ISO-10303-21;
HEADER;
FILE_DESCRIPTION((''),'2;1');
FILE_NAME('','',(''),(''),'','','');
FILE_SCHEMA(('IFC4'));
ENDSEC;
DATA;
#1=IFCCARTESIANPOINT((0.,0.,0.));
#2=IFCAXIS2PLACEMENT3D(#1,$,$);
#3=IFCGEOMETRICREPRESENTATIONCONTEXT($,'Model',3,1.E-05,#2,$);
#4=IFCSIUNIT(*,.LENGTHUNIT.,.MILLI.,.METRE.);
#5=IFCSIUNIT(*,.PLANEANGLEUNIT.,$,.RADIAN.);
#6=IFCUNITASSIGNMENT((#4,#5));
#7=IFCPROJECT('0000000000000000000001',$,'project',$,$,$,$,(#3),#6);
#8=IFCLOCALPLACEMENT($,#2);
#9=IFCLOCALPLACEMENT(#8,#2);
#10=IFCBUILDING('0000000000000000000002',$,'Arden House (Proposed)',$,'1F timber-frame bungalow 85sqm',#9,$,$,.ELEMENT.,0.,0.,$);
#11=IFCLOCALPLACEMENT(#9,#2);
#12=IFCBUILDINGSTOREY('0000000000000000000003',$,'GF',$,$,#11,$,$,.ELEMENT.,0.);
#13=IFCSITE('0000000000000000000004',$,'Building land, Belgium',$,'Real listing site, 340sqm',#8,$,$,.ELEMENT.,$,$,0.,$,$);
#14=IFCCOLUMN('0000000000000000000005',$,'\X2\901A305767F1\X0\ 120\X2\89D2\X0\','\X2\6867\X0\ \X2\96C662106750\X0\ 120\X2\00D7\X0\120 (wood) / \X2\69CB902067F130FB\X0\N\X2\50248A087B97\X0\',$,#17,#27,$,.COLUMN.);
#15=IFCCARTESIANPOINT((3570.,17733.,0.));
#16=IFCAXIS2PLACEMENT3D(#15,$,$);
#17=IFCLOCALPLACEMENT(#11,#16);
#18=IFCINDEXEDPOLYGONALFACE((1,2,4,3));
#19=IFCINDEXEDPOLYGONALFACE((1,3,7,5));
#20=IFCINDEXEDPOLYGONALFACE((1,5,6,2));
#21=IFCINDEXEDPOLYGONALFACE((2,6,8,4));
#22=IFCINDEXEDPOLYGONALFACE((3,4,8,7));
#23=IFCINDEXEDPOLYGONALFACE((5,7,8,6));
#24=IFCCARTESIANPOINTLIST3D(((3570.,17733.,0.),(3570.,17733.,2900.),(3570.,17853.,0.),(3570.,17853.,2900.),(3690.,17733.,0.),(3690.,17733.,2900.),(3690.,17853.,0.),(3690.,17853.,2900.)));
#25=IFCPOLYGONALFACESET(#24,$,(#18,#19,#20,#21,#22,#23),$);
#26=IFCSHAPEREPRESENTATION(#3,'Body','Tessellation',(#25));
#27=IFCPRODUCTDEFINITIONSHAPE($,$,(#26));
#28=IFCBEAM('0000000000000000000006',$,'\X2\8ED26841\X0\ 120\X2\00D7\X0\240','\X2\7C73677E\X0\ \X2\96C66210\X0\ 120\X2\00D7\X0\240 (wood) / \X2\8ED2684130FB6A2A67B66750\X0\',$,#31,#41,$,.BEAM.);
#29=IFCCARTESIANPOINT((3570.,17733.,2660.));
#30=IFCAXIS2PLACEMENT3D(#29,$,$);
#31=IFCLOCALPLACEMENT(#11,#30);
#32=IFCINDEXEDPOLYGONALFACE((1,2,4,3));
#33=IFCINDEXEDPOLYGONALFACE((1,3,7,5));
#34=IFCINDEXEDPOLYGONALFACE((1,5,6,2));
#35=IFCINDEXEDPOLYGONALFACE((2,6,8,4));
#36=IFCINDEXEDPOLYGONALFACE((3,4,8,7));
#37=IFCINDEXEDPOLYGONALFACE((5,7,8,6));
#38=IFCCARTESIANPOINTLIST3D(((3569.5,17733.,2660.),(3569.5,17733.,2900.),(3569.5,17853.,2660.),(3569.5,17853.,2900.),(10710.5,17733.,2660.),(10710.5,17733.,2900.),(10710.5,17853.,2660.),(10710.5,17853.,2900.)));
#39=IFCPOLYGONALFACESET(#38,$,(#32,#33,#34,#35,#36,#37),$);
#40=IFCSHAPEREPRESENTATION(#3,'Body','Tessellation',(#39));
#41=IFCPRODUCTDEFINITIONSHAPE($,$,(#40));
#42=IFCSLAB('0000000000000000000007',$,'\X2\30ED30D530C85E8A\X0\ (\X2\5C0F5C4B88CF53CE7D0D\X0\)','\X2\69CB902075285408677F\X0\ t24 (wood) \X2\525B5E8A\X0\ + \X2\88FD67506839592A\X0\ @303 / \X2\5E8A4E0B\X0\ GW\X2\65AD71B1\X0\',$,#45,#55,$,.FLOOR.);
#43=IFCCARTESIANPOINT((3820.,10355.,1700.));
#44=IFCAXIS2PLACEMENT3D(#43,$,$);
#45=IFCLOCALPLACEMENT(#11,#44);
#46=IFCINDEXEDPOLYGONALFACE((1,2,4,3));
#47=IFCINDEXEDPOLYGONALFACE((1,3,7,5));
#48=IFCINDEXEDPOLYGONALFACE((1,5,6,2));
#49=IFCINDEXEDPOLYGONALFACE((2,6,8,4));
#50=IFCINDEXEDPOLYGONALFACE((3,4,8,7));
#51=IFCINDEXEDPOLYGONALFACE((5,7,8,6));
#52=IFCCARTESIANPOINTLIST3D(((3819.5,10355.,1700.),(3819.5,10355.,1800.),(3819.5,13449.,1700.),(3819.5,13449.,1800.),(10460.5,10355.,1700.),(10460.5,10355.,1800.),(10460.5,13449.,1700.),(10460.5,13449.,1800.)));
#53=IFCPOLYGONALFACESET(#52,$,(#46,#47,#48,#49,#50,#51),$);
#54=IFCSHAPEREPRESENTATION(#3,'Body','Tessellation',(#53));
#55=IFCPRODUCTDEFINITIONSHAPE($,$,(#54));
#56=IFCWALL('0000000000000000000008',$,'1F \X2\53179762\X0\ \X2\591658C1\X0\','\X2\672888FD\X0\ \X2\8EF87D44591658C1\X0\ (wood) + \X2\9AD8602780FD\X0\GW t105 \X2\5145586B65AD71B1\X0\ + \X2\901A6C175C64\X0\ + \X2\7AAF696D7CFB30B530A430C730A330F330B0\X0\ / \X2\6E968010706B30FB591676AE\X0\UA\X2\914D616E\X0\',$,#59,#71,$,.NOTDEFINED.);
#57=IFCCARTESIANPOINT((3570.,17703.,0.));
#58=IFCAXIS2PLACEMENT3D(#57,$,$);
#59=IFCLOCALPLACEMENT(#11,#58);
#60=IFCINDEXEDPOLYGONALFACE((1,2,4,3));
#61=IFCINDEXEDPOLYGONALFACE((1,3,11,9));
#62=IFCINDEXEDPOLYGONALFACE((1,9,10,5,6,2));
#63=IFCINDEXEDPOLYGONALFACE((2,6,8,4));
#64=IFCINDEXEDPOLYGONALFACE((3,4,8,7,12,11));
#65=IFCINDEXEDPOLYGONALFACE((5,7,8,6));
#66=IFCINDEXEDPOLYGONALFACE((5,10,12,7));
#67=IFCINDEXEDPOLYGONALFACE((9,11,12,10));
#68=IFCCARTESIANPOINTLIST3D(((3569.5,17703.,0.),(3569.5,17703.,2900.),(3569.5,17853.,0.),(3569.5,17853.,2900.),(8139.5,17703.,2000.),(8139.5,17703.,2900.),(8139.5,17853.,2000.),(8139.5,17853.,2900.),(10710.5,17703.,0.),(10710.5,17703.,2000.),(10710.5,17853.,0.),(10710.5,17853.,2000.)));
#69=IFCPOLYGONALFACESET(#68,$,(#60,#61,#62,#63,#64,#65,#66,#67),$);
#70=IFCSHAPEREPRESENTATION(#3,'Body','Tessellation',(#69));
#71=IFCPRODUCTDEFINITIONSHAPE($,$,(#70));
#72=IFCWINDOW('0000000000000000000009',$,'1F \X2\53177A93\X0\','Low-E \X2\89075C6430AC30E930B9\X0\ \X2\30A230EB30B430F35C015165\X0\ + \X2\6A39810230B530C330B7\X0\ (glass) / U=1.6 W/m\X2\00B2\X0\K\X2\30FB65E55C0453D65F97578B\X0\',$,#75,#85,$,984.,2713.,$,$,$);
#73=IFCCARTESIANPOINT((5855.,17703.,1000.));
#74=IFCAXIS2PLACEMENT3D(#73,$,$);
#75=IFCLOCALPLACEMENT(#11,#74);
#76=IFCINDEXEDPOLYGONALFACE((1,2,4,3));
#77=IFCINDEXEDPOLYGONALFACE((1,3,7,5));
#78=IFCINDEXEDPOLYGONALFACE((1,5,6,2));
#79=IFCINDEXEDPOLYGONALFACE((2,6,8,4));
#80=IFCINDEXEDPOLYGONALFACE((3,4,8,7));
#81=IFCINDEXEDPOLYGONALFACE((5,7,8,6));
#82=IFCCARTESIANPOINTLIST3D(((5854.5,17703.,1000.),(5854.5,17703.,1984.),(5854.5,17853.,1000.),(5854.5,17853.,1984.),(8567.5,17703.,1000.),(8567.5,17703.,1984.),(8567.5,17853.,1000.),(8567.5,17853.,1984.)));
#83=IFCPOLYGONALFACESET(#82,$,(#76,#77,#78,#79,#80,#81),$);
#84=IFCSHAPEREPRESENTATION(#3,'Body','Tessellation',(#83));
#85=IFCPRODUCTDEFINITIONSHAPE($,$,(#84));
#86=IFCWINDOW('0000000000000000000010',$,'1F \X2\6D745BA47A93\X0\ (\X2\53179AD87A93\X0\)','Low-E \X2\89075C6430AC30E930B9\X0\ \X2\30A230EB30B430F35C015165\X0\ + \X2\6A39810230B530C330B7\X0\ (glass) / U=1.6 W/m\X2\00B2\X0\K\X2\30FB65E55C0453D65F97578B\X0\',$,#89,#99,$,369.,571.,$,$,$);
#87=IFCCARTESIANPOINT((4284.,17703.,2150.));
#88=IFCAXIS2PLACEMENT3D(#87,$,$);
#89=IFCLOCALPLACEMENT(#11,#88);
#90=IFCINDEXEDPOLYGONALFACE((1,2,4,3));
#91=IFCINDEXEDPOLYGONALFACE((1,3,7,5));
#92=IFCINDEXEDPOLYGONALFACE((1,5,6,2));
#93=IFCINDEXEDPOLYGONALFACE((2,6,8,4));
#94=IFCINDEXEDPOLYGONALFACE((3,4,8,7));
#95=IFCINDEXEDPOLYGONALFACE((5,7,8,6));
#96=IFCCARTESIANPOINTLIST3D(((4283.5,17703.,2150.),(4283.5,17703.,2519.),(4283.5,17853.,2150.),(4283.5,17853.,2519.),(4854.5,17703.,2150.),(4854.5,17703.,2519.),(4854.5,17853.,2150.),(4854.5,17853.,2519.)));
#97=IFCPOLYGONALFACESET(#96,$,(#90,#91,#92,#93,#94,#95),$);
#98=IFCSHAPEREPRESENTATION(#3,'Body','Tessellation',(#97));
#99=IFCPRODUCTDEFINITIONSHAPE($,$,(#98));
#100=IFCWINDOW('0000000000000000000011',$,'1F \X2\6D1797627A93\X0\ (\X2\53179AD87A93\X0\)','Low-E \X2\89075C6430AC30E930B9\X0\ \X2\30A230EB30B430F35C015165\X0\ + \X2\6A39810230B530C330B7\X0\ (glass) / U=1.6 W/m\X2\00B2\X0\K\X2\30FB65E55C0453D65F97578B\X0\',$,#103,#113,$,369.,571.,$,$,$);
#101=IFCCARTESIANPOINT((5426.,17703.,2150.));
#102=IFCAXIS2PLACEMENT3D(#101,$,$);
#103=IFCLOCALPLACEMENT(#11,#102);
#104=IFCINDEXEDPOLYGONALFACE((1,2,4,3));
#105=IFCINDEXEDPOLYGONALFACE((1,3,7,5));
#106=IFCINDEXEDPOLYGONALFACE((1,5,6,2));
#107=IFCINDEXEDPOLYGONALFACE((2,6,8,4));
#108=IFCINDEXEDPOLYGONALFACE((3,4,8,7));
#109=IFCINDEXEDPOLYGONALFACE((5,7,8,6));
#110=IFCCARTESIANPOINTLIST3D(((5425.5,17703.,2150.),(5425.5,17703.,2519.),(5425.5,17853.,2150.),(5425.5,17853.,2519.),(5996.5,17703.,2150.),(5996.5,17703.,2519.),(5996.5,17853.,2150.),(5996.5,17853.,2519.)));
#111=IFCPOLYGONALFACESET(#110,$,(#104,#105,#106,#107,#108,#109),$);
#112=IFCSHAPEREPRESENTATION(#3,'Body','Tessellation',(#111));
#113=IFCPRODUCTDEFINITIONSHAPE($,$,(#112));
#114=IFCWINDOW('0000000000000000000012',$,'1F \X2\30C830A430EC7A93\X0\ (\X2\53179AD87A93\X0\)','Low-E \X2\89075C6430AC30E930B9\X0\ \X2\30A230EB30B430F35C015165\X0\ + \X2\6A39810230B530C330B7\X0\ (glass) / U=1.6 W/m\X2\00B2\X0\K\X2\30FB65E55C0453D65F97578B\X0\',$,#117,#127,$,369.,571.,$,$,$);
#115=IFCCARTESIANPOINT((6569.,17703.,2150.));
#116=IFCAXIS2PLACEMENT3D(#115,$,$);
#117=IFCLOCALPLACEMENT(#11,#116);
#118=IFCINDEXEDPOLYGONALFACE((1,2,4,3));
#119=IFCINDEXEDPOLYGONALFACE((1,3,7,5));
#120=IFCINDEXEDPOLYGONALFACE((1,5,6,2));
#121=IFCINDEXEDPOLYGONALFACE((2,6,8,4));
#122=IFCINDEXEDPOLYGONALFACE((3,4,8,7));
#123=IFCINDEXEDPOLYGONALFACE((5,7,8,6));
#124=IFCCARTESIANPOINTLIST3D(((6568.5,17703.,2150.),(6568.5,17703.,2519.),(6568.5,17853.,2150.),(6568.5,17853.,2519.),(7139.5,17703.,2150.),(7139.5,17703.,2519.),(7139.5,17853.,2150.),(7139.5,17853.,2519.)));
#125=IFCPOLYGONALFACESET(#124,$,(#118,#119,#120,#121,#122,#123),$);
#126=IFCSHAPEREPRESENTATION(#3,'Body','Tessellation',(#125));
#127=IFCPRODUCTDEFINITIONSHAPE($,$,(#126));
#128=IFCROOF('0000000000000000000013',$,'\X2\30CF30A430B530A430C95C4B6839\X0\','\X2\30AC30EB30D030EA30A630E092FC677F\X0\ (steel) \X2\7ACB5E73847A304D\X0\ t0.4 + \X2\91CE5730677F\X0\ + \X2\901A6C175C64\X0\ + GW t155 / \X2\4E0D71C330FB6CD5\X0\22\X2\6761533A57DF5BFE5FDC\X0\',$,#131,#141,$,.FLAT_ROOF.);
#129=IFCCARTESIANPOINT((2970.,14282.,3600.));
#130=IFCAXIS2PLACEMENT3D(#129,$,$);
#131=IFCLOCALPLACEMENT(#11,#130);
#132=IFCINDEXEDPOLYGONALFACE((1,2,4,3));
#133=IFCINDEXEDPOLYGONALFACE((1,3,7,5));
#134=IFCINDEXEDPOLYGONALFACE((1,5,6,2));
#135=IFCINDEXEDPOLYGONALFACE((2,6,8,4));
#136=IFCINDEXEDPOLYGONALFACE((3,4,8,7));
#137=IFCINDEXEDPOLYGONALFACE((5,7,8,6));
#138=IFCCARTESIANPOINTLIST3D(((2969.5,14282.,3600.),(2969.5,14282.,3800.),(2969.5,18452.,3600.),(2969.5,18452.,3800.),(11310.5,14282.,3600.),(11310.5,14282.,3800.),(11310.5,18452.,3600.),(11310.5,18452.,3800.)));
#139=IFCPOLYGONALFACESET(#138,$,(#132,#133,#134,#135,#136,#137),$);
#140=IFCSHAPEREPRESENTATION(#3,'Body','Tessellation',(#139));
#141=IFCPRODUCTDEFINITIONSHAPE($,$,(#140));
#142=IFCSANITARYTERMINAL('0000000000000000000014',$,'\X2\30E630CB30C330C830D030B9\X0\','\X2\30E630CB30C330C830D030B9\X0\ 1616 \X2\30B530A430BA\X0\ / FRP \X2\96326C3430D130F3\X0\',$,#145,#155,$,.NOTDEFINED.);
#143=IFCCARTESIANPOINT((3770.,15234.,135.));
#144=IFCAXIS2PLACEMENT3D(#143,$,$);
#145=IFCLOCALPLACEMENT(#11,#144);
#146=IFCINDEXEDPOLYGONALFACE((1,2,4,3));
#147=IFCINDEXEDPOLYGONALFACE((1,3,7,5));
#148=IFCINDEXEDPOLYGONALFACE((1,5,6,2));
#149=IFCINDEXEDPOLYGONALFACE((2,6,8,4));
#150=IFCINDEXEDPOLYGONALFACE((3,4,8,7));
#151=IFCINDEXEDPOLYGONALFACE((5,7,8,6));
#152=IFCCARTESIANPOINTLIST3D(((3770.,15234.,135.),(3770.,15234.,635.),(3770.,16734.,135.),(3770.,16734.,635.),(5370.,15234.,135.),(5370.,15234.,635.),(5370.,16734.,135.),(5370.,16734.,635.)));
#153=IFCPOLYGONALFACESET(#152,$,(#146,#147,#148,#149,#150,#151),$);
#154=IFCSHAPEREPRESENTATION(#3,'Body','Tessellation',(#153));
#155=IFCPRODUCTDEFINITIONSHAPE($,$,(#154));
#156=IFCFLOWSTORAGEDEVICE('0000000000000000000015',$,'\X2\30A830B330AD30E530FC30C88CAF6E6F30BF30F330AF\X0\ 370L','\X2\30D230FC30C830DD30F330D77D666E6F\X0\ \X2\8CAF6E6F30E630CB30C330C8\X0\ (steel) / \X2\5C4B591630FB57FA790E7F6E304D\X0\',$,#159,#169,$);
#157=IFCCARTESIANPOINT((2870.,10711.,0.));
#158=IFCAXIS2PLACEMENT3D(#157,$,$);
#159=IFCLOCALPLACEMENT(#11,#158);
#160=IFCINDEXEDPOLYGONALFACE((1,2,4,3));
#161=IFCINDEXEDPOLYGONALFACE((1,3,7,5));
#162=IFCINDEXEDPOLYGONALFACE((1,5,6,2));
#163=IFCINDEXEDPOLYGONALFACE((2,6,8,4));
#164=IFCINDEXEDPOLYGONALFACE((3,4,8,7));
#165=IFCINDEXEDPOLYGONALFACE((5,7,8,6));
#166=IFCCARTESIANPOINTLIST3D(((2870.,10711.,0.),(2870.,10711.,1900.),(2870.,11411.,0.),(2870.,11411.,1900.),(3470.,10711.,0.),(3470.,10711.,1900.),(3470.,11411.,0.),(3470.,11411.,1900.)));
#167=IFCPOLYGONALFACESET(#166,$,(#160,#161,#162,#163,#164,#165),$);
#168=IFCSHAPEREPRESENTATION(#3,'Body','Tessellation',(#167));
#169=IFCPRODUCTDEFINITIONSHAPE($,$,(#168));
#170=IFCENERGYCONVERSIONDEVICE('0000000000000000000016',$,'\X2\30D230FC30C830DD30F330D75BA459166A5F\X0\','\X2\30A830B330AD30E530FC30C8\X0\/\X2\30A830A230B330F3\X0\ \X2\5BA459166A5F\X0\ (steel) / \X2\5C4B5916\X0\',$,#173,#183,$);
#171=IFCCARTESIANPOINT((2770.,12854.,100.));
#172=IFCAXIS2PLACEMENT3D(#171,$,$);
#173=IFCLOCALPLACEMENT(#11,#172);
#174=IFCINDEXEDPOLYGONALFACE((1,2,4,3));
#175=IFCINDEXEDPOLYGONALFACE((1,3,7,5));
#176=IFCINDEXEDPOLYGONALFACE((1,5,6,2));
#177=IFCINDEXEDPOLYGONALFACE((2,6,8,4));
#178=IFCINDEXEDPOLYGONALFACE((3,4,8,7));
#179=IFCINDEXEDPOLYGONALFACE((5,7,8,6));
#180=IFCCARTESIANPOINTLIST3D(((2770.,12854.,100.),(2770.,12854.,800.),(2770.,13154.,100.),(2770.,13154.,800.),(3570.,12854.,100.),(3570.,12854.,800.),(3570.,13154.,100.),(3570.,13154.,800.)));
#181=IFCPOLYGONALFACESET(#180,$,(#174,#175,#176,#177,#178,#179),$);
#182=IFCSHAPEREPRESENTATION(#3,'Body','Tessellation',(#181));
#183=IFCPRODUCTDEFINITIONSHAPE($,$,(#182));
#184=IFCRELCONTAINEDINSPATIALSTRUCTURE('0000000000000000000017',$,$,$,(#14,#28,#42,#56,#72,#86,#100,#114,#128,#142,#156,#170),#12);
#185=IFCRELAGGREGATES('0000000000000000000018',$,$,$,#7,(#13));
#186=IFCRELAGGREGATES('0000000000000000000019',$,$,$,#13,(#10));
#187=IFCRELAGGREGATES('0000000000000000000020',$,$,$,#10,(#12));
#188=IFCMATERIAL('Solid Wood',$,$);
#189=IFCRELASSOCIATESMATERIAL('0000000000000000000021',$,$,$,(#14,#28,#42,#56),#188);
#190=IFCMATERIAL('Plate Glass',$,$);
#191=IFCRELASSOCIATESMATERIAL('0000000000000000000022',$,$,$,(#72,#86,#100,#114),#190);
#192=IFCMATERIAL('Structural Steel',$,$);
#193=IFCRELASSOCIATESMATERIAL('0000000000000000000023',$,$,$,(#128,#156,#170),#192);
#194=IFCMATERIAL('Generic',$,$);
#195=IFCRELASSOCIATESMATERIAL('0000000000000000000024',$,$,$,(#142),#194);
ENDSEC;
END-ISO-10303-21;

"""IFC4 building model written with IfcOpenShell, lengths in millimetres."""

from ifc_helpers import new_model, si_unit, frame, frame_2d, origin, place, context, project, spatial, rectangle, extrude, material, element, fill, save


model = new_model("IFC4")

# Units and contexts
model_context = context("Model", 3, precision=1e-05, world=origin())
ifc_project = project(units=[si_unit("LENGTHUNIT", "METRE", prefix="MILLI"), si_unit("PLANEANGLEUNIT", "RADIAN")], contexts=[model_context])

# Site, building, storey
site_placement = place(None, origin())
site = spatial("IfcSite", under=ifc_project, at=site_placement, Name="Building land, Belgium", ObjectType="Real listing site, 340sqm", CompositionType="ELEMENT", RefElevation=0.0)
building_placement = place(site_placement, origin())
building = spatial("IfcBuilding", under=site, at=building_placement, Name="Arden House (Proposed)", ObjectType="1F timber-frame bungalow 85sqm", CompositionType="ELEMENT", ElevationOfRefHeight=0.0, ElevationOfTerrain=0.0)
storey_placement = place(building_placement, origin())
storey = spatial("IfcBuildingStorey", under=building, at=storey_placement, Name="GF", CompositionType="ELEMENT", Elevation=0.0)

# Column
ifc_material_1 = material(Name="Solid Wood")
column_1_placement = place(storey_placement, frame((3570.0, 17733.0, 0.0)))
element("IfcColumn", 1, at=column_1_placement, inside=storey, material=ifc_material_1, Name="通し柱 120角", Description="桧 集成材 120×120 (wood) / 構造柱・N値計算", PredefinedType="COLUMN", context=model_context, shape_type="SweptSolid", body=[
    extrude(rectangle(XDim=120.0, YDim=120.0, at=frame_2d((60.0, 60.0))), frame((3570.0, 17733.0, 0.0)), (0.0, 0.0, 1.0), 2900.0),
])

# Beam
beam_1_placement = place(storey_placement, frame((3570.0, 17733.0, 2660.0)))
element("IfcBeam", 2, at=beam_1_placement, inside=storey, material=ifc_material_1, Name="軒桁 120×240", Description="米松 集成 120×240 (wood) / 軒桁・横架材", PredefinedType="BEAM", context=model_context, shape_type="SweptSolid", body=[
    extrude(rectangle(XDim=7141.0, YDim=120.0, at=frame_2d((3570.0, 60.0))), frame((3570.0, 17733.0, 2660.0)), (0.0, 0.0, 1.0), 240.0),
])

# Slab
slab_placement = place(storey_placement, frame((3820.0, 10355.0, 1700.0)))
element("IfcSlab", 3, at=slab_placement, inside=storey, material=ifc_material_1, Name="ロフト床 (小屋裏収納)", Description="構造用合板 t24 (wood) 剛床 + 製材根太 @303 / 床下 GW断熱", PredefinedType="FLOOR", context=model_context, shape_type="SweptSolid", body=[
    extrude(rectangle(XDim=6641.0, YDim=3094.0, at=frame_2d((3320.0, 1547.0))), frame((3820.0, 10355.0, 1700.0)), (0.0, 0.0, 1.0), 100.0),
])

# Wall, openings, windows
wall_1_placement = place(storey_placement, frame((3570.0, 17703.0, 0.0)))
wall_1 = element("IfcWall", 4, at=wall_1_placement, inside=storey, material=ifc_material_1, Name="1F 北面 外壁", Description="木製 軸組外壁 (wood) + 高性能GW t105 充填断熱 + 通気層 + 窯業系サイディング / 準耐火・外皮UA配慮", PredefinedType="NOTDEFINED", context=model_context, shape_type="SweptSolid", body=[
    extrude(rectangle(XDim=7141.0, YDim=150.0, at=frame_2d((3570.0, 75.0))), frame((3570.0, 17703.0, 0.0)), (0.0, 0.0, 1.0), 2900.0),
])
opening_1_placement = place(storey_placement, frame((5855.0, 17703.0, 1000.0)))
opening_1 = element("IfcOpeningElement", 5, at=opening_1_placement, cuts=wall_1, PredefinedType="NOTDEFINED", context=model_context, shape_type="SweptSolid", body=[
    extrude(rectangle(XDim=2713.0, YDim=150.0, at=frame_2d((1356.0, 75.0))), frame((5855.0, 17703.0, 1000.0)), (0.0, 0.0, 1.0), 984.0),
])
opening_2_placement = place(storey_placement, frame((4284.0, 17703.0, 2150.0)))
opening_2 = element("IfcOpeningElement", 6, at=opening_2_placement, cuts=wall_1, PredefinedType="NOTDEFINED", context=model_context, shape_type="SweptSolid", body=[
    extrude(rectangle(XDim=571.0, YDim=150.0, at=frame_2d((285.0, 75.0))), frame((4284.0, 17703.0, 2150.0)), (0.0, 0.0, 1.0), 369.0),
])
opening_3_placement = place(storey_placement, frame((5426.0, 17703.0, 2150.0)))
opening_3 = element("IfcOpeningElement", 7, at=opening_3_placement, cuts=wall_1, PredefinedType="NOTDEFINED", context=model_context, shape_type="SweptSolid", body=[
    extrude(rectangle(XDim=571.0, YDim=150.0, at=frame_2d((285.0, 75.0))), frame((5426.0, 17703.0, 2150.0)), (0.0, 0.0, 1.0), 369.0),
])
opening_4_placement = place(storey_placement, frame((6569.0, 17703.0, 2150.0)))
opening_4 = element("IfcOpeningElement", 8, at=opening_4_placement, cuts=wall_1, PredefinedType="NOTDEFINED", context=model_context, shape_type="SweptSolid", body=[
    extrude(rectangle(XDim=571.0, YDim=150.0, at=frame_2d((285.0, 75.0))), frame((6569.0, 17703.0, 2150.0)), (0.0, 0.0, 1.0), 369.0),
])
ifc_material_2 = material(Name="Plate Glass")
window_1_placement = place(storey_placement, frame((5855.0, 17703.0, 1000.0)))
window_1 = element("IfcWindow", 9, at=window_1_placement, inside=storey, material=ifc_material_2, Name="1F 北窓", Description="Low-E 複層ガラス アルゴン封入 + 樹脂サッシ (glass) / U=1.6 W/m²K・日射取得型", OverallHeight=984.0, OverallWidth=2713.0, context=model_context, shape_type="SweptSolid", body=[
    extrude(rectangle(XDim=2713.0, YDim=150.0, at=frame_2d((1356.0, 75.0))), frame((5855.0, 17703.0, 1000.0)), (0.0, 0.0, 1.0), 984.0),
])
fill(opening_1, window_1)
window_2_placement = place(storey_placement, frame((4284.0, 17703.0, 2150.0)))
window_2 = element("IfcWindow", 10, at=window_2_placement, inside=storey, material=ifc_material_2, Name="1F 浴室窓 (北高窓)", Description="Low-E 複層ガラス アルゴン封入 + 樹脂サッシ (glass) / U=1.6 W/m²K・日射取得型", OverallHeight=369.0, OverallWidth=571.0, context=model_context, shape_type="SweptSolid", body=[
    extrude(rectangle(XDim=571.0, YDim=150.0, at=frame_2d((285.0, 75.0))), frame((4284.0, 17703.0, 2150.0)), (0.0, 0.0, 1.0), 369.0),
])
fill(opening_2, window_2)
window_3_placement = place(storey_placement, frame((5426.0, 17703.0, 2150.0)))
window_3 = element("IfcWindow", 11, at=window_3_placement, inside=storey, material=ifc_material_2, Name="1F 洗面窓 (北高窓)", Description="Low-E 複層ガラス アルゴン封入 + 樹脂サッシ (glass) / U=1.6 W/m²K・日射取得型", OverallHeight=369.0, OverallWidth=571.0, context=model_context, shape_type="SweptSolid", body=[
    extrude(rectangle(XDim=571.0, YDim=150.0, at=frame_2d((285.0, 75.0))), frame((5426.0, 17703.0, 2150.0)), (0.0, 0.0, 1.0), 369.0),
])
fill(opening_3, window_3)
window_4_placement = place(storey_placement, frame((6569.0, 17703.0, 2150.0)))
window_4 = element("IfcWindow", 12, at=window_4_placement, inside=storey, material=ifc_material_2, Name="1F トイレ窓 (北高窓)", Description="Low-E 複層ガラス アルゴン封入 + 樹脂サッシ (glass) / U=1.6 W/m²K・日射取得型", OverallHeight=369.0, OverallWidth=571.0, context=model_context, shape_type="SweptSolid", body=[
    extrude(rectangle(XDim=571.0, YDim=150.0, at=frame_2d((285.0, 75.0))), frame((6569.0, 17703.0, 2150.0)), (0.0, 0.0, 1.0), 369.0),
])
fill(opening_4, window_4)

# Roof
ifc_material_3 = material(Name="Structural Steel")
roof_placement = place(storey_placement, frame((2970.0, 14282.0, 3600.0)))
element("IfcRoof", 13, at=roof_placement, inside=storey, material=ifc_material_3, Name="ハイサイド屋根", Description="ガルバリウム鋼板 (steel) 立平葺き t0.4 + 野地板 + 通気層 + GW t155 / 不燃・法22条区域対応", PredefinedType="FLAT_ROOF", context=model_context, shape_type="SweptSolid", body=[
    extrude(rectangle(XDim=8341.0, YDim=4170.0, at=frame_2d((4170.0, 2085.0))), frame((2970.0, 14282.0, 3600.0)), (0.0, 0.0, 1.0), 200.0),
])

# Sanitary terminal
ifc_material_4 = material(Name="Generic")
sanitary_terminal_placement = place(storey_placement, frame((3770.0, 15234.0, 135.0)))
element("IfcSanitaryTerminal", 14, at=sanitary_terminal_placement, inside=storey, material=ifc_material_4, Name="ユニットバス", Description="ユニットバス 1616 サイズ / FRP 防水パン", PredefinedType="NOTDEFINED", context=model_context, shape_type="SweptSolid", body=[
    extrude(rectangle(XDim=1600.0, YDim=1500.0, at=frame_2d((800.0, 750.0))), frame((3770.0, 15234.0, 135.0)), (0.0, 0.0, 1.0), 500.0),
])

# Flow storage device
flow_storage_device_placement = place(storey_placement, frame((2870.0, 10711.0, 0.0)))
element("IfcFlowStorageDevice", 15, at=flow_storage_device_placement, inside=storey, material=ifc_material_3, Name="エコキュート貯湯タンク 370L", Description="ヒートポンプ給湯 貯湯ユニット (steel) / 屋外・基礎置き", context=model_context, shape_type="SweptSolid", body=[
    extrude(rectangle(XDim=600.0, YDim=700.0, at=frame_2d((300.0, 350.0))), frame((2870.0, 10711.0, 0.0)), (0.0, 0.0, 1.0), 1900.0),
])

# Energy conversion device
energy_conversion_device_placement = place(storey_placement, frame((2770.0, 12854.0, 100.0)))
element("IfcEnergyConversionDevice", 16, at=energy_conversion_device_placement, inside=storey, material=ifc_material_3, Name="ヒートポンプ室外機", Description="エコキュート/エアコン 室外機 (steel) / 屋外", context=model_context, shape_type="SweptSolid", body=[
    extrude(rectangle(XDim=800.0, YDim=300.0, at=frame_2d((400.0, 150.0))), frame((2770.0, 12854.0, 100.0)), (0.0, 0.0, 1.0), 700.0),
])

save(model, "model.ifc")
